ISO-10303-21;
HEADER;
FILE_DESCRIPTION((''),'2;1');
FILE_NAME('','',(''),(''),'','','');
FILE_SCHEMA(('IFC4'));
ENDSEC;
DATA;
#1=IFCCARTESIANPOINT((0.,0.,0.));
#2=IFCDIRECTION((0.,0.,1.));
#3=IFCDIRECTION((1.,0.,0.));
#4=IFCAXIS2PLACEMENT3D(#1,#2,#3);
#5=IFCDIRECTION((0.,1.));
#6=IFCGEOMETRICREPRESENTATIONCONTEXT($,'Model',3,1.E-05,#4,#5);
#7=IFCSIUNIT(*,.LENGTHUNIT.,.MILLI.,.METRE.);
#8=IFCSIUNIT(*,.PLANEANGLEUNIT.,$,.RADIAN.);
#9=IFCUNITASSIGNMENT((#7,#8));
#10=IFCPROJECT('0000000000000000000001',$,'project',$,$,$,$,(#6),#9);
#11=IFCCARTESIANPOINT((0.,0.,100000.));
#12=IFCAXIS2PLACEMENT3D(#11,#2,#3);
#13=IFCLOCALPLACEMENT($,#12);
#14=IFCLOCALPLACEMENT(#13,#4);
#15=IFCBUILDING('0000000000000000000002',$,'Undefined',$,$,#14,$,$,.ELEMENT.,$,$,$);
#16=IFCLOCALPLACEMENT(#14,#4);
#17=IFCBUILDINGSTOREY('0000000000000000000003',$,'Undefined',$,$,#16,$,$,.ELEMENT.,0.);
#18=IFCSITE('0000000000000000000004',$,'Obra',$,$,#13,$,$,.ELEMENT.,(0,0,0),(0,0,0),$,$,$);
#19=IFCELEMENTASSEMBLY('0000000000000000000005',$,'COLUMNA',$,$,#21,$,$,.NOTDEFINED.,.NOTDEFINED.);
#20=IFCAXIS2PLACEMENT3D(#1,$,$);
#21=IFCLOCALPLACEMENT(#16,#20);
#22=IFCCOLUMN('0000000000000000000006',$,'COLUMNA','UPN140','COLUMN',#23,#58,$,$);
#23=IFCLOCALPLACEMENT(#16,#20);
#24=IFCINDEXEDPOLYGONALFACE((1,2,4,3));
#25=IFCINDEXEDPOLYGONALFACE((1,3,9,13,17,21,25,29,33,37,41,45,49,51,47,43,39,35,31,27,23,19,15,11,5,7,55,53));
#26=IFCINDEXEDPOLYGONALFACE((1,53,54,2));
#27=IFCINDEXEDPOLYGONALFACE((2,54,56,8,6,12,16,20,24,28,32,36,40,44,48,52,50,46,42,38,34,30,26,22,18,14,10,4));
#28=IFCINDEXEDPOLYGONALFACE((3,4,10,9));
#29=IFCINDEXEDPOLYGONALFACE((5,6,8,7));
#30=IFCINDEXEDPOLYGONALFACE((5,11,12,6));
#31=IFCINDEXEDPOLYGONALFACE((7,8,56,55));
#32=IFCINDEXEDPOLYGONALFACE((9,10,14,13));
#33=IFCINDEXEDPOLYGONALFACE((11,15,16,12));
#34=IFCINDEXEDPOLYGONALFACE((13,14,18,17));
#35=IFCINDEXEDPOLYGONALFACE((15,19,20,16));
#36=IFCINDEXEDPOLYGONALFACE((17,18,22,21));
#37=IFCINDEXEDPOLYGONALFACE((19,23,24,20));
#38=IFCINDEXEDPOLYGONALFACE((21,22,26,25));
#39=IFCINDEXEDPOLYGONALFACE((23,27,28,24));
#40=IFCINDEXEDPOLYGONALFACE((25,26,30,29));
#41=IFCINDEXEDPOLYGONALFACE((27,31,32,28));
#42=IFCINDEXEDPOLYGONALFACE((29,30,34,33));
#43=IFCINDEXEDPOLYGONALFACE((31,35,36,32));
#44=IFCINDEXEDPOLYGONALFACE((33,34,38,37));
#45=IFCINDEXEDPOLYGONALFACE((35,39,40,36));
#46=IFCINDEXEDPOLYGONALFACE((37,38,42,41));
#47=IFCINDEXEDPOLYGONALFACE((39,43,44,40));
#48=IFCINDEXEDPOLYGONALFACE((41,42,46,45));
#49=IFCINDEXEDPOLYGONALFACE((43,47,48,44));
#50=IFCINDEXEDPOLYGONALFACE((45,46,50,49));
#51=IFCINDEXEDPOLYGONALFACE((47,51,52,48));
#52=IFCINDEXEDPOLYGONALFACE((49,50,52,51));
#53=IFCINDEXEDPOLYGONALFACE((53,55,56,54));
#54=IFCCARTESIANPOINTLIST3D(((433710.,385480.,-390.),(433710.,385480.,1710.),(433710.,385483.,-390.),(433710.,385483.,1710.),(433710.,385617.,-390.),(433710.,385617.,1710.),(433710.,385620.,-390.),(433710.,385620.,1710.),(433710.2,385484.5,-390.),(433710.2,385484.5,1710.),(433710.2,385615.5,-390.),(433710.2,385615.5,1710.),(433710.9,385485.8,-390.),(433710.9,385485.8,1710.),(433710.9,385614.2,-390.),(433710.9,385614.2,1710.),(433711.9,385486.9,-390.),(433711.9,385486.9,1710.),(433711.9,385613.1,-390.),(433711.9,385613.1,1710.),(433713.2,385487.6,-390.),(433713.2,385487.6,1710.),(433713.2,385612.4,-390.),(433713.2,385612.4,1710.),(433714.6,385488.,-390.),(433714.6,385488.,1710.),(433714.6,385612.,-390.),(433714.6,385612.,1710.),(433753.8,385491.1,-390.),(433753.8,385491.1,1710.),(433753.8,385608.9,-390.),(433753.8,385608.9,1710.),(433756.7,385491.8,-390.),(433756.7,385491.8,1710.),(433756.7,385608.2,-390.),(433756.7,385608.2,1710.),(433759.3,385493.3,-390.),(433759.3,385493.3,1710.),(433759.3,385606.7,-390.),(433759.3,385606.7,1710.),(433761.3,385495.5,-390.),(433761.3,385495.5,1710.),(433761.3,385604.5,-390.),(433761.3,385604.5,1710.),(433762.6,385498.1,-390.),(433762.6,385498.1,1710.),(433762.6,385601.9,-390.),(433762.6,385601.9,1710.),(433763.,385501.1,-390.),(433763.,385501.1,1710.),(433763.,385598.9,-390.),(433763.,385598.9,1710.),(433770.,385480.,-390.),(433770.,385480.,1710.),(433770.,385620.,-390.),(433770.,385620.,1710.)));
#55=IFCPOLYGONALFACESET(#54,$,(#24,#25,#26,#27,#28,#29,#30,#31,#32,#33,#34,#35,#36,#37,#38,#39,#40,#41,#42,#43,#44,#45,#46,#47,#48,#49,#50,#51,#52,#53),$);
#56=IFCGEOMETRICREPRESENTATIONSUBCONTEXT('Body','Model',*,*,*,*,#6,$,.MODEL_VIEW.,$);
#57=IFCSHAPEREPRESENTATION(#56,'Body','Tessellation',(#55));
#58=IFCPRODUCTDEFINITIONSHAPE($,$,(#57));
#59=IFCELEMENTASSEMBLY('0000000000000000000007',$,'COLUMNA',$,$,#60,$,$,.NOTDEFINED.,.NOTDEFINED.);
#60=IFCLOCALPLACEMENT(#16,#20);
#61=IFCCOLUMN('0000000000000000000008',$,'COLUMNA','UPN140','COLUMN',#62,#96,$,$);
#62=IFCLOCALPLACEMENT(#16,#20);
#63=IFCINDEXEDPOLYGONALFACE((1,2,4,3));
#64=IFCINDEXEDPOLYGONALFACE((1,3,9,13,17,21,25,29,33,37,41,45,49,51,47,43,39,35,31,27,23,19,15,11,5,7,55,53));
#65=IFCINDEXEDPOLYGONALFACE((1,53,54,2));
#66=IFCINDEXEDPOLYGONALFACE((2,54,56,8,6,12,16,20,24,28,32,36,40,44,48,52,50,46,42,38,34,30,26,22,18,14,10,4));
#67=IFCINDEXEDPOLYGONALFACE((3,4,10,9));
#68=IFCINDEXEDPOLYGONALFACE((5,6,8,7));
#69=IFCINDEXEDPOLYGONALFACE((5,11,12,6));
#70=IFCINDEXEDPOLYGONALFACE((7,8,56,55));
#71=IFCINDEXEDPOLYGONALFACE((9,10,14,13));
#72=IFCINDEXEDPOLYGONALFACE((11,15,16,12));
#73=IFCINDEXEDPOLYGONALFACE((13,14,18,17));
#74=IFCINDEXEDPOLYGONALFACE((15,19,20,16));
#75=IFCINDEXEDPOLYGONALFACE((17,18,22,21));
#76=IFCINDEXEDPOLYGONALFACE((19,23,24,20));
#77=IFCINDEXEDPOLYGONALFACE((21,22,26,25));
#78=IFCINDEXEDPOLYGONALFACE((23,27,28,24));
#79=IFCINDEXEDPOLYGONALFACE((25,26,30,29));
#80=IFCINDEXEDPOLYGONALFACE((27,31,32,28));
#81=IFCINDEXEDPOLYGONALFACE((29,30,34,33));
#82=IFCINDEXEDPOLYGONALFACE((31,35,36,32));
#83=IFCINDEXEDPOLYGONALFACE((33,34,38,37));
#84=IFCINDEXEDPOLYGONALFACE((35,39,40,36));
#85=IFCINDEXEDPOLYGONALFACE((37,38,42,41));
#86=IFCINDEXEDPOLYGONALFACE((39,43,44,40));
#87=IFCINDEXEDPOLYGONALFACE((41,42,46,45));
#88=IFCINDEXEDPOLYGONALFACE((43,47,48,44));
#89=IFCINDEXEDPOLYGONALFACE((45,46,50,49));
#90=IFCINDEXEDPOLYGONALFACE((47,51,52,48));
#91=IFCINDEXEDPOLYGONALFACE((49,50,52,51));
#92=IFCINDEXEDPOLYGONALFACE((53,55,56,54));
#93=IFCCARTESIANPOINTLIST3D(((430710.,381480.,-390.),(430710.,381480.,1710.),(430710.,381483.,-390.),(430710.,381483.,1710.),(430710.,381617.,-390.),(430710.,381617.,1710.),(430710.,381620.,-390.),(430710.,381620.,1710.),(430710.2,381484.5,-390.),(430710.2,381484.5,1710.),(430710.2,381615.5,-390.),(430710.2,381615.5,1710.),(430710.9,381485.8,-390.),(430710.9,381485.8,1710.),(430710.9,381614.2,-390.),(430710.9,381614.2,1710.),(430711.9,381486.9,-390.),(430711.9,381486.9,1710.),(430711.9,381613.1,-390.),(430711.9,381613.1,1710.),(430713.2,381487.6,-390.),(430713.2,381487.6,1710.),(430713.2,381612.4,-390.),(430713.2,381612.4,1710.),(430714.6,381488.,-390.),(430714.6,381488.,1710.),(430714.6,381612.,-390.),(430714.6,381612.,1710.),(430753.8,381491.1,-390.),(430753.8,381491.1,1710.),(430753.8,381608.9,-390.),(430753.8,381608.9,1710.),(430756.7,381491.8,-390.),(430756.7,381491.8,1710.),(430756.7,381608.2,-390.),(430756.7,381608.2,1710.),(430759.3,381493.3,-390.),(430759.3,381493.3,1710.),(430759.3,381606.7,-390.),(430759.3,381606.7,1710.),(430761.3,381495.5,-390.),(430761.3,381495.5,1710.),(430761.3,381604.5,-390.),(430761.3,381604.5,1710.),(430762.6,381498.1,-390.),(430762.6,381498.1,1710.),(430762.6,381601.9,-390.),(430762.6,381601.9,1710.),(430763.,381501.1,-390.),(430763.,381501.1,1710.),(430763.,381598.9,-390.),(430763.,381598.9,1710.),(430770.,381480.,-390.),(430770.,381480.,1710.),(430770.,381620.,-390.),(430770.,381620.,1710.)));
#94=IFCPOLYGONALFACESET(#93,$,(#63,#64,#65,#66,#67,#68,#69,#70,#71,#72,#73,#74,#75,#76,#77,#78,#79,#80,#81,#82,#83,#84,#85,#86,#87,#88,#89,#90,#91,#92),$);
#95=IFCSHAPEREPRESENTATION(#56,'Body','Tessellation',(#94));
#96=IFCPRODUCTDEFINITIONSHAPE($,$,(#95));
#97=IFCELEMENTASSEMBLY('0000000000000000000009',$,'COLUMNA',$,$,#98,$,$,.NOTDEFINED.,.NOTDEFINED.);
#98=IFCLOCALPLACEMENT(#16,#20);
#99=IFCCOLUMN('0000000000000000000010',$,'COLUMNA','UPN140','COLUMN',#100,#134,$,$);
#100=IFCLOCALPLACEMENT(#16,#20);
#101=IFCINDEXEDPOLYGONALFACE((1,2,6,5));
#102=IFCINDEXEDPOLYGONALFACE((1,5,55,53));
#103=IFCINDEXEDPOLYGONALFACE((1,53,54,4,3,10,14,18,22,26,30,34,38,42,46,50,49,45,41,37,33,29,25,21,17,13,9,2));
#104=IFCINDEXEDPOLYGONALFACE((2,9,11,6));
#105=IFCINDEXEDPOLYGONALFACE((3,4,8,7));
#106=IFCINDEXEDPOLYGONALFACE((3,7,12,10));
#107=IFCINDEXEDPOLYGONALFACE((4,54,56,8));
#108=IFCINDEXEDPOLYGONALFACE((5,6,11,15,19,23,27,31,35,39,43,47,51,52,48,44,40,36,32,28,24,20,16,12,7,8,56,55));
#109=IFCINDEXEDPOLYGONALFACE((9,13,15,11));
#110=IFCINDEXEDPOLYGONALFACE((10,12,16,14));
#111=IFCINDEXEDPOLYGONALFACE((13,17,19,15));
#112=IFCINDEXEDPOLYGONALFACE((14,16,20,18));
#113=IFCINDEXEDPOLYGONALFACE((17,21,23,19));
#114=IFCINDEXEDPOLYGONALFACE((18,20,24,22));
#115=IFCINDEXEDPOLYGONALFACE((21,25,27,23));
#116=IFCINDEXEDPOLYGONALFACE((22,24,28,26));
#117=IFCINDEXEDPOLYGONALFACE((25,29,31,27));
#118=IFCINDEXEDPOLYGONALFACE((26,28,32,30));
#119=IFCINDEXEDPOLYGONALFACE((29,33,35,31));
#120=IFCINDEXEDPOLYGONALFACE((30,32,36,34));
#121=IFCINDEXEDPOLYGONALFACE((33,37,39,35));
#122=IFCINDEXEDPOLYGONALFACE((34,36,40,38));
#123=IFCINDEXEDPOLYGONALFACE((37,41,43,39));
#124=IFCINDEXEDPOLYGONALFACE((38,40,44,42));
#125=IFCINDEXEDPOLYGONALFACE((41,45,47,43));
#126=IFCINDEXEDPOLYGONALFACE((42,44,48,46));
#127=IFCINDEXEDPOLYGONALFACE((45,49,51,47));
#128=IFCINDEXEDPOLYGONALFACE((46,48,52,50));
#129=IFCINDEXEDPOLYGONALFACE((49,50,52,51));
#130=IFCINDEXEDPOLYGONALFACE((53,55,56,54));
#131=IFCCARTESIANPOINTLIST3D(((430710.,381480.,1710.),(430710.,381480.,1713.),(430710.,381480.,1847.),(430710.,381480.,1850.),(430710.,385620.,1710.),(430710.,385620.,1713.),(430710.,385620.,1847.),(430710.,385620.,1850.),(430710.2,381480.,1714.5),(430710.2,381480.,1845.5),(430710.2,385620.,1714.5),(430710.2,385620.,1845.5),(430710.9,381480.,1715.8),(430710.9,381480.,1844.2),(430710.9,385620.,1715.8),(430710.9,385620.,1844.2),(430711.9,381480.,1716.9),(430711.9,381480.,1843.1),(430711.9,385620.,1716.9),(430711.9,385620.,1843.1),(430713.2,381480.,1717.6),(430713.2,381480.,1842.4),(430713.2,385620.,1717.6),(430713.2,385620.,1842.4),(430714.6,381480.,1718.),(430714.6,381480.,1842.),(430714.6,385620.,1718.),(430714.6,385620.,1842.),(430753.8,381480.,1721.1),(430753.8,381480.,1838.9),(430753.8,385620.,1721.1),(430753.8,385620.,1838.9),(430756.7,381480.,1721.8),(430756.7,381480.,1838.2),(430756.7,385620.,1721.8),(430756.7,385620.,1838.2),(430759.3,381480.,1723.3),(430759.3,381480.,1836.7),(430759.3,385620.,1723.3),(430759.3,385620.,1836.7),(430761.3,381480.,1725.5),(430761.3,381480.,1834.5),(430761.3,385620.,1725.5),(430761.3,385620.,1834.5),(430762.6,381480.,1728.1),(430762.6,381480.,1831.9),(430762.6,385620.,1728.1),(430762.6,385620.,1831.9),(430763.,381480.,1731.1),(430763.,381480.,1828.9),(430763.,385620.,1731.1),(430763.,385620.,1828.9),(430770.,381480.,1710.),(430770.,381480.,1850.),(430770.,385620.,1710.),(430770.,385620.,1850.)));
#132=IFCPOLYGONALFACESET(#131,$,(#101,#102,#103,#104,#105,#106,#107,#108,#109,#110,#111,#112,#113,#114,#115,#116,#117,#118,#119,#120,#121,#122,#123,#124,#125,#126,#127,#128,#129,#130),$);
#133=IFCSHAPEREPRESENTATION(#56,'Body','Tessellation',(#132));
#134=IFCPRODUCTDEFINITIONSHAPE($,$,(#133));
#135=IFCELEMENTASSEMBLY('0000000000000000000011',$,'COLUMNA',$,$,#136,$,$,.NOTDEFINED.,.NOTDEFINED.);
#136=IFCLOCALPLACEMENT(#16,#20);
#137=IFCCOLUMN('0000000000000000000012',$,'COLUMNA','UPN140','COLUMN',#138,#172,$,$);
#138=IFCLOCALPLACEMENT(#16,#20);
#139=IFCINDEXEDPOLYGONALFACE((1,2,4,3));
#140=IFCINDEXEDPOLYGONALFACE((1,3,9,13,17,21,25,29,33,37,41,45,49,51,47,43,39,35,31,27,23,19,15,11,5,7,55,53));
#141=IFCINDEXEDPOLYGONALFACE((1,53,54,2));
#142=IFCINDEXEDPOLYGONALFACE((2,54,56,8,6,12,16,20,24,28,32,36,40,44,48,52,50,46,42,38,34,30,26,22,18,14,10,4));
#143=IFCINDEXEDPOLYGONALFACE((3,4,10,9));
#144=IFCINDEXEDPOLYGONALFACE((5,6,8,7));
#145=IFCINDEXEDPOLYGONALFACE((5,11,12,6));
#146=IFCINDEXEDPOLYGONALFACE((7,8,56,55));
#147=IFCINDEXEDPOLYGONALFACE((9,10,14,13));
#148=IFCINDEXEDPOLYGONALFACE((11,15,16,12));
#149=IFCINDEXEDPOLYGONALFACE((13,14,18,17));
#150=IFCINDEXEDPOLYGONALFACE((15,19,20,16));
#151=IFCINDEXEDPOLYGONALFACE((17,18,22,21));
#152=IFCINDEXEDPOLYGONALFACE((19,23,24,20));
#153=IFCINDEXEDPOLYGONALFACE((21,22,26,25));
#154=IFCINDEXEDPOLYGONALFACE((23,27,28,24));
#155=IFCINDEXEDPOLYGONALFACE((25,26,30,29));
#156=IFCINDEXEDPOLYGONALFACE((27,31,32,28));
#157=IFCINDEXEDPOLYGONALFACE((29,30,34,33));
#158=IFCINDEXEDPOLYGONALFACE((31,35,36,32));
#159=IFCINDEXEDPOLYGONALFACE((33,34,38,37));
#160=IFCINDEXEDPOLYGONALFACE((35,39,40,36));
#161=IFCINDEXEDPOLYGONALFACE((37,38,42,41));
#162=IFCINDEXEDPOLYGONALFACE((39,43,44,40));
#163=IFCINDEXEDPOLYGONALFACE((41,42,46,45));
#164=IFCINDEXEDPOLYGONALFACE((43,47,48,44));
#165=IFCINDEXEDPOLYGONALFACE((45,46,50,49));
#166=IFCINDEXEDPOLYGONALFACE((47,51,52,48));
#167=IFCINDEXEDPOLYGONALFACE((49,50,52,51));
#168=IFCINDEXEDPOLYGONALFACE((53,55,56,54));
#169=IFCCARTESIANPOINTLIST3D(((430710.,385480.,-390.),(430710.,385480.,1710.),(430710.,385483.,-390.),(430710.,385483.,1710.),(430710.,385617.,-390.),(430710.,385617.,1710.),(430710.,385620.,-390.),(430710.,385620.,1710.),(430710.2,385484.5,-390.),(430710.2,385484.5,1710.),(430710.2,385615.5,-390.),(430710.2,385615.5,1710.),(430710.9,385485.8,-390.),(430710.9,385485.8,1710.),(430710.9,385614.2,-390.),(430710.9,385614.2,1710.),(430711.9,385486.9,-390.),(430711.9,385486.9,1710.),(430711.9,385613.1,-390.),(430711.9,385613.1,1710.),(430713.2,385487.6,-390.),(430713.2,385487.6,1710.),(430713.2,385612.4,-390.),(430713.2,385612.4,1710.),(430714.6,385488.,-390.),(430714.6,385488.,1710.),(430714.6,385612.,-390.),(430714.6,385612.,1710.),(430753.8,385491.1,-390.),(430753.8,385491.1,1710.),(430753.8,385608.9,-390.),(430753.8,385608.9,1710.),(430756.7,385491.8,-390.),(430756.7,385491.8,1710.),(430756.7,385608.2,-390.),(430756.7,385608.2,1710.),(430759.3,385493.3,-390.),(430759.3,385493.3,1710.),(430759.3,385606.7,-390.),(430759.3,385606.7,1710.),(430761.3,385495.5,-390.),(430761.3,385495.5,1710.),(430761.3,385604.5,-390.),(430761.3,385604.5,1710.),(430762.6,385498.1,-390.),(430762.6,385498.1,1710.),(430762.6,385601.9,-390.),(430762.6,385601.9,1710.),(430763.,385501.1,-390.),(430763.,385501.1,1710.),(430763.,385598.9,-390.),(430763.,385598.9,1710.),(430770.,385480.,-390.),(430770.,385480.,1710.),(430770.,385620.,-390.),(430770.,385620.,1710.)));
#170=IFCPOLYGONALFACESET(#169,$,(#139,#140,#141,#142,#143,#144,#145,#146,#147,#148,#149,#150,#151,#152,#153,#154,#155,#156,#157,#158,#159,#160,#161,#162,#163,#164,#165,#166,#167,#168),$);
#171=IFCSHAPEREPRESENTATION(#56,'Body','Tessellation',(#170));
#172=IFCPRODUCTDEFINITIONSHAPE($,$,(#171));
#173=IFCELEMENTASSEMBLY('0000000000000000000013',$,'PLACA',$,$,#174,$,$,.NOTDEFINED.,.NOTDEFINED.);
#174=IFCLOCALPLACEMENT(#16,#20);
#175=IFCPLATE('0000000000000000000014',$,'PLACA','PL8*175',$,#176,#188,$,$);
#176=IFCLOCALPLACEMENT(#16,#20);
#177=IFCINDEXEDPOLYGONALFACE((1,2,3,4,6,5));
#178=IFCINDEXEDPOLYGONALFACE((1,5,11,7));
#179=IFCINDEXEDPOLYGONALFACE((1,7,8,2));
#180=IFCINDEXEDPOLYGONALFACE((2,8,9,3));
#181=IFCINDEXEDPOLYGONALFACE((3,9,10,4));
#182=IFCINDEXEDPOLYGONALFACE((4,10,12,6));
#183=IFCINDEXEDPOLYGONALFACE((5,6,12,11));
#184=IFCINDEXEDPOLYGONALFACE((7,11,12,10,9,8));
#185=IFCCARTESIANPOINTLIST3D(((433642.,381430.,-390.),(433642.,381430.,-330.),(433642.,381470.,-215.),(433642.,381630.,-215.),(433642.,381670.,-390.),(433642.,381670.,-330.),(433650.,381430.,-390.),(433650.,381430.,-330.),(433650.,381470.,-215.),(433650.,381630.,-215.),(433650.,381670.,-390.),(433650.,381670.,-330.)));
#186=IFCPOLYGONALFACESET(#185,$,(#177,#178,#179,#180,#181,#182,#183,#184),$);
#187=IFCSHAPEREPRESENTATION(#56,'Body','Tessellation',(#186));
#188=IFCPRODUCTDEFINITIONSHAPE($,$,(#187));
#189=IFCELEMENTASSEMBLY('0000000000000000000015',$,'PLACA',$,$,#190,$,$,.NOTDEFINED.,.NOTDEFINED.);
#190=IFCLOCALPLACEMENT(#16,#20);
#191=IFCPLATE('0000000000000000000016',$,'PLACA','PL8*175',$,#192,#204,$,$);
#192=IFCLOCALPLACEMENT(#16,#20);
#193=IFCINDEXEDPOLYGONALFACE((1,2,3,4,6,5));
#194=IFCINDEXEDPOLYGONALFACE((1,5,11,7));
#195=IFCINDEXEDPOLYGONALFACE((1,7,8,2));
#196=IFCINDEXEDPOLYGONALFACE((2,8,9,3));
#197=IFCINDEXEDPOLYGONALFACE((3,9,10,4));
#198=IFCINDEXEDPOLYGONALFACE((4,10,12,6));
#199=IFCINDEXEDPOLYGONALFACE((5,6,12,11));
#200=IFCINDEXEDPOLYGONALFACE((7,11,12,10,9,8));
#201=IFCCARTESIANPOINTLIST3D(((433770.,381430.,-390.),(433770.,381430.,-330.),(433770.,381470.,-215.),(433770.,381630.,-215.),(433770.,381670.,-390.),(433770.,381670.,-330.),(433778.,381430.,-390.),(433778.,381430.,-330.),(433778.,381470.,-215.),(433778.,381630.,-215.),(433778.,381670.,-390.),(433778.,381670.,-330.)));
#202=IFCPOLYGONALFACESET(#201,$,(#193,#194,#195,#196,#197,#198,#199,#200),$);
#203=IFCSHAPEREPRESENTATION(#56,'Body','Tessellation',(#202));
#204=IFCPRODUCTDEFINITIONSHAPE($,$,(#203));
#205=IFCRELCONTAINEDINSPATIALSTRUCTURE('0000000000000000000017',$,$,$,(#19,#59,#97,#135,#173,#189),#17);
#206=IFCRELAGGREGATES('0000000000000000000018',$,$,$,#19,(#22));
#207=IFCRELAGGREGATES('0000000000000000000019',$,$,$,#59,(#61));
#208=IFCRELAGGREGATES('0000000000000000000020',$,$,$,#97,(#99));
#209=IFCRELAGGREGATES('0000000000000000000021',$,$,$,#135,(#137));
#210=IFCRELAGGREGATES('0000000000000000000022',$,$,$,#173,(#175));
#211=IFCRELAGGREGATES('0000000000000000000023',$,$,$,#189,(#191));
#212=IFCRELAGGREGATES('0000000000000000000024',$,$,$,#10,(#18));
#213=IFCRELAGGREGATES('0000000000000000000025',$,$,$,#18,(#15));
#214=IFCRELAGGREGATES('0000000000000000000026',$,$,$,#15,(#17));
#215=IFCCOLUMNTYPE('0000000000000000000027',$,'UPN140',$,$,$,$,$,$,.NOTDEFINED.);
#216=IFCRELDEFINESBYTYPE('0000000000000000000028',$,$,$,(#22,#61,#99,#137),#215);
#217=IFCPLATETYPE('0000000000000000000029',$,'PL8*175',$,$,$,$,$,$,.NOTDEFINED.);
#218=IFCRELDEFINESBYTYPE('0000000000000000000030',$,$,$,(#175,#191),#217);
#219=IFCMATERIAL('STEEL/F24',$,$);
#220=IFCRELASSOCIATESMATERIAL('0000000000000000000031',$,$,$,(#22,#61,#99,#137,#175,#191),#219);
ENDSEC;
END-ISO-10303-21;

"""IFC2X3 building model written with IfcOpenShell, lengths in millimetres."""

from ifc_helpers import new_model, si_unit, direction, frame, origin_with_axes, origin_2d_with_axis, place, context, subcontext, project, spatial, polyline, u_section, outline, extrude, material, type_object, element, aggregate, save


model = new_model("IFC2X3")

# Units and contexts
model_context = context("Model", 3, precision=1e-05, world=origin_with_axes(), true_north=direction((0.0, 1.0)))
body_context = subcontext(model_context, "Body", "Model", "MODEL_VIEW")
ifc_project = project(units=[si_unit("LENGTHUNIT", "METRE", prefix="MILLI"), si_unit("PLANEANGLEUNIT", "RADIAN")], contexts=[model_context])

# Site, building, storey
site_placement = place(None, frame((0.0, 0.0, 100000.0), z_axis=(0.0, 0.0, 1.0), x_axis=(1.0, 0.0, 0.0)))
site = spatial("IfcSite", under=ifc_project, at=site_placement, Name="Obra", CompositionType="ELEMENT", RefLatitude=(0, 0, 0), RefLongitude=(0, 0, 0))
building_placement = place(site_placement, origin_with_axes())
building = spatial("IfcBuilding", under=site, at=building_placement, Name="Undefined", CompositionType="ELEMENT")
storey_placement = place(building_placement, origin_with_axes())
storey = spatial("IfcBuildingStorey", under=building, at=storey_placement, Name="Undefined", CompositionType="ELEMENT", Elevation=0.0)

# Element assemblies, columns
ifc_material_1 = material(Name="STEEL/F24")
column_type_1 = type_object("IfcColumnType", Name="UPN140", PredefinedType="NOTDEFINED")
assembly_1_placement = place(storey_placement, origin_with_axes())
assembly_1 = element("IfcElementAssembly", 1, at=assembly_1_placement, inside=storey, Name="COLUMNA", AssemblyPlace="NOTDEFINED", PredefinedType="NOTDEFINED")
column_1_placement = place(assembly_1_placement, frame((433740.0, 385550.0, -390.0), z_axis=(0.0, 0.0, 1.0), x_axis=(0.0, 1.0, 0.0)))
column_1 = element("IfcColumn", 2, at=column_1_placement, type_object=column_type_1, material=ifc_material_1, Name="COLUMNA", Description="UPN140", ObjectType="COLUMN", context=body_context, shape_type="SweptSolid", body=[
    extrude(u_section(Depth=140.0, FlangeWidth=60.0, WebThickness=7.0, FlangeThickness=10.0, FilletRadius=10.0, EdgeRadius=5.0, FlangeSlope=0.07983, at=origin_2d_with_axis()), frame((0.0, 0.0, 2100.0), z_axis=(0.0, 0.0, -1.0), x_axis=(0.0, 1.0, 0.0)), (0.0, 0.0, 1.0), 2100.0),
])
aggregate(assembly_1, [column_1])
assembly_2_placement = place(storey_placement, origin_with_axes())
assembly_2 = element("IfcElementAssembly", 3, at=assembly_2_placement, inside=storey, Name="COLUMNA", AssemblyPlace="NOTDEFINED", PredefinedType="NOTDEFINED")
column_2_placement = place(assembly_2_placement, frame((430740.0, 381550.0, 1710.0), z_axis=(0.0, 0.0, -1.0), x_axis=(0.0, -1.0, 0.0)))
column_2 = element("IfcColumn", 4, at=column_2_placement, type_object=column_type_1, material=ifc_material_1, Name="COLUMNA", Description="UPN140", ObjectType="COLUMN", context=body_context, shape_type="SweptSolid", body=[
    extrude(u_section(Depth=140.0, FlangeWidth=60.0, WebThickness=7.0, FlangeThickness=10.0, FilletRadius=10.0, EdgeRadius=5.0, FlangeSlope=0.07983, at=origin_2d_with_axis()), frame((0.0, 0.0, 2100.0), z_axis=(0.0, 0.0, -1.0), x_axis=(0.0, 1.0, 0.0)), (0.0, 0.0, 1.0), 2100.0),
])
aggregate(assembly_2, [column_2])
assembly_3_placement = place(storey_placement, origin_with_axes())
assembly_3 = element("IfcElementAssembly", 5, at=assembly_3_placement, inside=storey, Name="COLUMNA", AssemblyPlace="NOTDEFINED", PredefinedType="NOTDEFINED")
column_3_placement = place(assembly_3_placement, frame((430740.0, 385620.0, 1780.0), z_axis=(0.0, -1.0, 0.0), x_axis=(0.0, 0.0, 1.0)))
column_3 = element("IfcColumn", 6, at=column_3_placement, type_object=column_type_1, material=ifc_material_1, Name="COLUMNA", Description="UPN140", ObjectType="COLUMN", context=body_context, shape_type="SweptSolid", body=[
    extrude(u_section(Depth=140.0, FlangeWidth=60.0, WebThickness=7.0, FlangeThickness=10.0, FilletRadius=10.0, EdgeRadius=5.0, FlangeSlope=0.07983, at=origin_2d_with_axis()), frame((0.0, 0.0, 4140.0), z_axis=(0.0, 0.0, -1.0), x_axis=(0.0, 1.0, 0.0)), (0.0, 0.0, 1.0), 4140.0),
])
aggregate(assembly_3, [column_3])
assembly_4_placement = place(storey_placement, origin_with_axes())
assembly_4 = element("IfcElementAssembly", 7, at=assembly_4_placement, inside=storey, Name="COLUMNA", AssemblyPlace="NOTDEFINED", PredefinedType="NOTDEFINED")
column_4_placement = place(assembly_4_placement, frame((430740.0, 385550.0, -390.0), z_axis=(0.0, 0.0, 1.0), x_axis=(0.0, 1.0, 0.0)))
column_4 = element("IfcColumn", 8, at=column_4_placement, type_object=column_type_1, material=ifc_material_1, Name="COLUMNA", Description="UPN140", ObjectType="COLUMN", context=body_context, shape_type="SweptSolid", body=[
    extrude(u_section(Depth=140.0, FlangeWidth=60.0, WebThickness=7.0, FlangeThickness=10.0, FilletRadius=10.0, EdgeRadius=5.0, FlangeSlope=0.07983, at=origin_2d_with_axis()), frame((0.0, 0.0, 2100.0), z_axis=(0.0, 0.0, -1.0), x_axis=(0.0, 1.0, 0.0)), (0.0, 0.0, 1.0), 2100.0),
])
aggregate(assembly_4, [column_4])

# Element assemblies, plates
assembly_5_placement = place(storey_placement, origin_with_axes())
assembly_5 = element("IfcElementAssembly", 9, at=assembly_5_placement, inside=storey, Name="PLACA", AssemblyPlace="NOTDEFINED", PredefinedType="NOTDEFINED")
plate_type_1 = type_object("IfcPlateType", Name="PL8*175", PredefinedType="NOTDEFINED")
plate_1_placement = place(assembly_5_placement, frame((433646.0, 381630.0, -215.0), z_axis=(-1.0, 0.0, 0.0), x_axis=(0.0, 0.328521, -0.944497)))
plate_1 = element("IfcPlate", 10, at=plate_1_placement, type_object=plate_type_1, material=ifc_material_1, Name="PLACA", Description="PL8*175", context=body_context, shape_type="SweptSolid", body=[
    extrude(outline(polyline([(0.0, 0.0), (121.8, 0.0), (178.4, 19.7), (99.6, 246.4), (42.9, 226.7), (-52.6, 151.1), (0.0, 0.0)])), frame((0.0, 0.0, -4.0), z_axis=(0.0, 0.0, 1.0), x_axis=(1.0, 0.0, 0.0)), (0.0, 0.0, 1.0), 8.0),
])
aggregate(assembly_5, [plate_1])
assembly_6_placement = place(storey_placement, origin_with_axes())
assembly_6 = element("IfcElementAssembly", 11, at=assembly_6_placement, inside=storey, Name="PLACA", AssemblyPlace="NOTDEFINED", PredefinedType="NOTDEFINED")
plate_2_placement = place(assembly_6_placement, frame((433774.0, 381630.0, -215.0), z_axis=(-1.0, 0.0, 0.0), x_axis=(0.0, 0.328521, -0.944497)))
plate_2 = element("IfcPlate", 12, at=plate_2_placement, type_object=plate_type_1, material=ifc_material_1, Name="PLACA", Description="PL8*175", context=body_context, shape_type="SweptSolid", body=[
    extrude(outline(polyline([(0.0, 0.0), (121.8, 0.0), (178.4, 19.7), (99.6, 246.4), (42.9, 226.7), (-52.6, 151.1), (0.0, 0.0)])), frame((0.0, 0.0, -4.0), z_axis=(0.0, 0.0, 1.0), x_axis=(1.0, 0.0, 0.0)), (0.0, 0.0, 1.0), 8.0),
])
aggregate(assembly_6, [plate_2])

save(model, "model.ifc")
